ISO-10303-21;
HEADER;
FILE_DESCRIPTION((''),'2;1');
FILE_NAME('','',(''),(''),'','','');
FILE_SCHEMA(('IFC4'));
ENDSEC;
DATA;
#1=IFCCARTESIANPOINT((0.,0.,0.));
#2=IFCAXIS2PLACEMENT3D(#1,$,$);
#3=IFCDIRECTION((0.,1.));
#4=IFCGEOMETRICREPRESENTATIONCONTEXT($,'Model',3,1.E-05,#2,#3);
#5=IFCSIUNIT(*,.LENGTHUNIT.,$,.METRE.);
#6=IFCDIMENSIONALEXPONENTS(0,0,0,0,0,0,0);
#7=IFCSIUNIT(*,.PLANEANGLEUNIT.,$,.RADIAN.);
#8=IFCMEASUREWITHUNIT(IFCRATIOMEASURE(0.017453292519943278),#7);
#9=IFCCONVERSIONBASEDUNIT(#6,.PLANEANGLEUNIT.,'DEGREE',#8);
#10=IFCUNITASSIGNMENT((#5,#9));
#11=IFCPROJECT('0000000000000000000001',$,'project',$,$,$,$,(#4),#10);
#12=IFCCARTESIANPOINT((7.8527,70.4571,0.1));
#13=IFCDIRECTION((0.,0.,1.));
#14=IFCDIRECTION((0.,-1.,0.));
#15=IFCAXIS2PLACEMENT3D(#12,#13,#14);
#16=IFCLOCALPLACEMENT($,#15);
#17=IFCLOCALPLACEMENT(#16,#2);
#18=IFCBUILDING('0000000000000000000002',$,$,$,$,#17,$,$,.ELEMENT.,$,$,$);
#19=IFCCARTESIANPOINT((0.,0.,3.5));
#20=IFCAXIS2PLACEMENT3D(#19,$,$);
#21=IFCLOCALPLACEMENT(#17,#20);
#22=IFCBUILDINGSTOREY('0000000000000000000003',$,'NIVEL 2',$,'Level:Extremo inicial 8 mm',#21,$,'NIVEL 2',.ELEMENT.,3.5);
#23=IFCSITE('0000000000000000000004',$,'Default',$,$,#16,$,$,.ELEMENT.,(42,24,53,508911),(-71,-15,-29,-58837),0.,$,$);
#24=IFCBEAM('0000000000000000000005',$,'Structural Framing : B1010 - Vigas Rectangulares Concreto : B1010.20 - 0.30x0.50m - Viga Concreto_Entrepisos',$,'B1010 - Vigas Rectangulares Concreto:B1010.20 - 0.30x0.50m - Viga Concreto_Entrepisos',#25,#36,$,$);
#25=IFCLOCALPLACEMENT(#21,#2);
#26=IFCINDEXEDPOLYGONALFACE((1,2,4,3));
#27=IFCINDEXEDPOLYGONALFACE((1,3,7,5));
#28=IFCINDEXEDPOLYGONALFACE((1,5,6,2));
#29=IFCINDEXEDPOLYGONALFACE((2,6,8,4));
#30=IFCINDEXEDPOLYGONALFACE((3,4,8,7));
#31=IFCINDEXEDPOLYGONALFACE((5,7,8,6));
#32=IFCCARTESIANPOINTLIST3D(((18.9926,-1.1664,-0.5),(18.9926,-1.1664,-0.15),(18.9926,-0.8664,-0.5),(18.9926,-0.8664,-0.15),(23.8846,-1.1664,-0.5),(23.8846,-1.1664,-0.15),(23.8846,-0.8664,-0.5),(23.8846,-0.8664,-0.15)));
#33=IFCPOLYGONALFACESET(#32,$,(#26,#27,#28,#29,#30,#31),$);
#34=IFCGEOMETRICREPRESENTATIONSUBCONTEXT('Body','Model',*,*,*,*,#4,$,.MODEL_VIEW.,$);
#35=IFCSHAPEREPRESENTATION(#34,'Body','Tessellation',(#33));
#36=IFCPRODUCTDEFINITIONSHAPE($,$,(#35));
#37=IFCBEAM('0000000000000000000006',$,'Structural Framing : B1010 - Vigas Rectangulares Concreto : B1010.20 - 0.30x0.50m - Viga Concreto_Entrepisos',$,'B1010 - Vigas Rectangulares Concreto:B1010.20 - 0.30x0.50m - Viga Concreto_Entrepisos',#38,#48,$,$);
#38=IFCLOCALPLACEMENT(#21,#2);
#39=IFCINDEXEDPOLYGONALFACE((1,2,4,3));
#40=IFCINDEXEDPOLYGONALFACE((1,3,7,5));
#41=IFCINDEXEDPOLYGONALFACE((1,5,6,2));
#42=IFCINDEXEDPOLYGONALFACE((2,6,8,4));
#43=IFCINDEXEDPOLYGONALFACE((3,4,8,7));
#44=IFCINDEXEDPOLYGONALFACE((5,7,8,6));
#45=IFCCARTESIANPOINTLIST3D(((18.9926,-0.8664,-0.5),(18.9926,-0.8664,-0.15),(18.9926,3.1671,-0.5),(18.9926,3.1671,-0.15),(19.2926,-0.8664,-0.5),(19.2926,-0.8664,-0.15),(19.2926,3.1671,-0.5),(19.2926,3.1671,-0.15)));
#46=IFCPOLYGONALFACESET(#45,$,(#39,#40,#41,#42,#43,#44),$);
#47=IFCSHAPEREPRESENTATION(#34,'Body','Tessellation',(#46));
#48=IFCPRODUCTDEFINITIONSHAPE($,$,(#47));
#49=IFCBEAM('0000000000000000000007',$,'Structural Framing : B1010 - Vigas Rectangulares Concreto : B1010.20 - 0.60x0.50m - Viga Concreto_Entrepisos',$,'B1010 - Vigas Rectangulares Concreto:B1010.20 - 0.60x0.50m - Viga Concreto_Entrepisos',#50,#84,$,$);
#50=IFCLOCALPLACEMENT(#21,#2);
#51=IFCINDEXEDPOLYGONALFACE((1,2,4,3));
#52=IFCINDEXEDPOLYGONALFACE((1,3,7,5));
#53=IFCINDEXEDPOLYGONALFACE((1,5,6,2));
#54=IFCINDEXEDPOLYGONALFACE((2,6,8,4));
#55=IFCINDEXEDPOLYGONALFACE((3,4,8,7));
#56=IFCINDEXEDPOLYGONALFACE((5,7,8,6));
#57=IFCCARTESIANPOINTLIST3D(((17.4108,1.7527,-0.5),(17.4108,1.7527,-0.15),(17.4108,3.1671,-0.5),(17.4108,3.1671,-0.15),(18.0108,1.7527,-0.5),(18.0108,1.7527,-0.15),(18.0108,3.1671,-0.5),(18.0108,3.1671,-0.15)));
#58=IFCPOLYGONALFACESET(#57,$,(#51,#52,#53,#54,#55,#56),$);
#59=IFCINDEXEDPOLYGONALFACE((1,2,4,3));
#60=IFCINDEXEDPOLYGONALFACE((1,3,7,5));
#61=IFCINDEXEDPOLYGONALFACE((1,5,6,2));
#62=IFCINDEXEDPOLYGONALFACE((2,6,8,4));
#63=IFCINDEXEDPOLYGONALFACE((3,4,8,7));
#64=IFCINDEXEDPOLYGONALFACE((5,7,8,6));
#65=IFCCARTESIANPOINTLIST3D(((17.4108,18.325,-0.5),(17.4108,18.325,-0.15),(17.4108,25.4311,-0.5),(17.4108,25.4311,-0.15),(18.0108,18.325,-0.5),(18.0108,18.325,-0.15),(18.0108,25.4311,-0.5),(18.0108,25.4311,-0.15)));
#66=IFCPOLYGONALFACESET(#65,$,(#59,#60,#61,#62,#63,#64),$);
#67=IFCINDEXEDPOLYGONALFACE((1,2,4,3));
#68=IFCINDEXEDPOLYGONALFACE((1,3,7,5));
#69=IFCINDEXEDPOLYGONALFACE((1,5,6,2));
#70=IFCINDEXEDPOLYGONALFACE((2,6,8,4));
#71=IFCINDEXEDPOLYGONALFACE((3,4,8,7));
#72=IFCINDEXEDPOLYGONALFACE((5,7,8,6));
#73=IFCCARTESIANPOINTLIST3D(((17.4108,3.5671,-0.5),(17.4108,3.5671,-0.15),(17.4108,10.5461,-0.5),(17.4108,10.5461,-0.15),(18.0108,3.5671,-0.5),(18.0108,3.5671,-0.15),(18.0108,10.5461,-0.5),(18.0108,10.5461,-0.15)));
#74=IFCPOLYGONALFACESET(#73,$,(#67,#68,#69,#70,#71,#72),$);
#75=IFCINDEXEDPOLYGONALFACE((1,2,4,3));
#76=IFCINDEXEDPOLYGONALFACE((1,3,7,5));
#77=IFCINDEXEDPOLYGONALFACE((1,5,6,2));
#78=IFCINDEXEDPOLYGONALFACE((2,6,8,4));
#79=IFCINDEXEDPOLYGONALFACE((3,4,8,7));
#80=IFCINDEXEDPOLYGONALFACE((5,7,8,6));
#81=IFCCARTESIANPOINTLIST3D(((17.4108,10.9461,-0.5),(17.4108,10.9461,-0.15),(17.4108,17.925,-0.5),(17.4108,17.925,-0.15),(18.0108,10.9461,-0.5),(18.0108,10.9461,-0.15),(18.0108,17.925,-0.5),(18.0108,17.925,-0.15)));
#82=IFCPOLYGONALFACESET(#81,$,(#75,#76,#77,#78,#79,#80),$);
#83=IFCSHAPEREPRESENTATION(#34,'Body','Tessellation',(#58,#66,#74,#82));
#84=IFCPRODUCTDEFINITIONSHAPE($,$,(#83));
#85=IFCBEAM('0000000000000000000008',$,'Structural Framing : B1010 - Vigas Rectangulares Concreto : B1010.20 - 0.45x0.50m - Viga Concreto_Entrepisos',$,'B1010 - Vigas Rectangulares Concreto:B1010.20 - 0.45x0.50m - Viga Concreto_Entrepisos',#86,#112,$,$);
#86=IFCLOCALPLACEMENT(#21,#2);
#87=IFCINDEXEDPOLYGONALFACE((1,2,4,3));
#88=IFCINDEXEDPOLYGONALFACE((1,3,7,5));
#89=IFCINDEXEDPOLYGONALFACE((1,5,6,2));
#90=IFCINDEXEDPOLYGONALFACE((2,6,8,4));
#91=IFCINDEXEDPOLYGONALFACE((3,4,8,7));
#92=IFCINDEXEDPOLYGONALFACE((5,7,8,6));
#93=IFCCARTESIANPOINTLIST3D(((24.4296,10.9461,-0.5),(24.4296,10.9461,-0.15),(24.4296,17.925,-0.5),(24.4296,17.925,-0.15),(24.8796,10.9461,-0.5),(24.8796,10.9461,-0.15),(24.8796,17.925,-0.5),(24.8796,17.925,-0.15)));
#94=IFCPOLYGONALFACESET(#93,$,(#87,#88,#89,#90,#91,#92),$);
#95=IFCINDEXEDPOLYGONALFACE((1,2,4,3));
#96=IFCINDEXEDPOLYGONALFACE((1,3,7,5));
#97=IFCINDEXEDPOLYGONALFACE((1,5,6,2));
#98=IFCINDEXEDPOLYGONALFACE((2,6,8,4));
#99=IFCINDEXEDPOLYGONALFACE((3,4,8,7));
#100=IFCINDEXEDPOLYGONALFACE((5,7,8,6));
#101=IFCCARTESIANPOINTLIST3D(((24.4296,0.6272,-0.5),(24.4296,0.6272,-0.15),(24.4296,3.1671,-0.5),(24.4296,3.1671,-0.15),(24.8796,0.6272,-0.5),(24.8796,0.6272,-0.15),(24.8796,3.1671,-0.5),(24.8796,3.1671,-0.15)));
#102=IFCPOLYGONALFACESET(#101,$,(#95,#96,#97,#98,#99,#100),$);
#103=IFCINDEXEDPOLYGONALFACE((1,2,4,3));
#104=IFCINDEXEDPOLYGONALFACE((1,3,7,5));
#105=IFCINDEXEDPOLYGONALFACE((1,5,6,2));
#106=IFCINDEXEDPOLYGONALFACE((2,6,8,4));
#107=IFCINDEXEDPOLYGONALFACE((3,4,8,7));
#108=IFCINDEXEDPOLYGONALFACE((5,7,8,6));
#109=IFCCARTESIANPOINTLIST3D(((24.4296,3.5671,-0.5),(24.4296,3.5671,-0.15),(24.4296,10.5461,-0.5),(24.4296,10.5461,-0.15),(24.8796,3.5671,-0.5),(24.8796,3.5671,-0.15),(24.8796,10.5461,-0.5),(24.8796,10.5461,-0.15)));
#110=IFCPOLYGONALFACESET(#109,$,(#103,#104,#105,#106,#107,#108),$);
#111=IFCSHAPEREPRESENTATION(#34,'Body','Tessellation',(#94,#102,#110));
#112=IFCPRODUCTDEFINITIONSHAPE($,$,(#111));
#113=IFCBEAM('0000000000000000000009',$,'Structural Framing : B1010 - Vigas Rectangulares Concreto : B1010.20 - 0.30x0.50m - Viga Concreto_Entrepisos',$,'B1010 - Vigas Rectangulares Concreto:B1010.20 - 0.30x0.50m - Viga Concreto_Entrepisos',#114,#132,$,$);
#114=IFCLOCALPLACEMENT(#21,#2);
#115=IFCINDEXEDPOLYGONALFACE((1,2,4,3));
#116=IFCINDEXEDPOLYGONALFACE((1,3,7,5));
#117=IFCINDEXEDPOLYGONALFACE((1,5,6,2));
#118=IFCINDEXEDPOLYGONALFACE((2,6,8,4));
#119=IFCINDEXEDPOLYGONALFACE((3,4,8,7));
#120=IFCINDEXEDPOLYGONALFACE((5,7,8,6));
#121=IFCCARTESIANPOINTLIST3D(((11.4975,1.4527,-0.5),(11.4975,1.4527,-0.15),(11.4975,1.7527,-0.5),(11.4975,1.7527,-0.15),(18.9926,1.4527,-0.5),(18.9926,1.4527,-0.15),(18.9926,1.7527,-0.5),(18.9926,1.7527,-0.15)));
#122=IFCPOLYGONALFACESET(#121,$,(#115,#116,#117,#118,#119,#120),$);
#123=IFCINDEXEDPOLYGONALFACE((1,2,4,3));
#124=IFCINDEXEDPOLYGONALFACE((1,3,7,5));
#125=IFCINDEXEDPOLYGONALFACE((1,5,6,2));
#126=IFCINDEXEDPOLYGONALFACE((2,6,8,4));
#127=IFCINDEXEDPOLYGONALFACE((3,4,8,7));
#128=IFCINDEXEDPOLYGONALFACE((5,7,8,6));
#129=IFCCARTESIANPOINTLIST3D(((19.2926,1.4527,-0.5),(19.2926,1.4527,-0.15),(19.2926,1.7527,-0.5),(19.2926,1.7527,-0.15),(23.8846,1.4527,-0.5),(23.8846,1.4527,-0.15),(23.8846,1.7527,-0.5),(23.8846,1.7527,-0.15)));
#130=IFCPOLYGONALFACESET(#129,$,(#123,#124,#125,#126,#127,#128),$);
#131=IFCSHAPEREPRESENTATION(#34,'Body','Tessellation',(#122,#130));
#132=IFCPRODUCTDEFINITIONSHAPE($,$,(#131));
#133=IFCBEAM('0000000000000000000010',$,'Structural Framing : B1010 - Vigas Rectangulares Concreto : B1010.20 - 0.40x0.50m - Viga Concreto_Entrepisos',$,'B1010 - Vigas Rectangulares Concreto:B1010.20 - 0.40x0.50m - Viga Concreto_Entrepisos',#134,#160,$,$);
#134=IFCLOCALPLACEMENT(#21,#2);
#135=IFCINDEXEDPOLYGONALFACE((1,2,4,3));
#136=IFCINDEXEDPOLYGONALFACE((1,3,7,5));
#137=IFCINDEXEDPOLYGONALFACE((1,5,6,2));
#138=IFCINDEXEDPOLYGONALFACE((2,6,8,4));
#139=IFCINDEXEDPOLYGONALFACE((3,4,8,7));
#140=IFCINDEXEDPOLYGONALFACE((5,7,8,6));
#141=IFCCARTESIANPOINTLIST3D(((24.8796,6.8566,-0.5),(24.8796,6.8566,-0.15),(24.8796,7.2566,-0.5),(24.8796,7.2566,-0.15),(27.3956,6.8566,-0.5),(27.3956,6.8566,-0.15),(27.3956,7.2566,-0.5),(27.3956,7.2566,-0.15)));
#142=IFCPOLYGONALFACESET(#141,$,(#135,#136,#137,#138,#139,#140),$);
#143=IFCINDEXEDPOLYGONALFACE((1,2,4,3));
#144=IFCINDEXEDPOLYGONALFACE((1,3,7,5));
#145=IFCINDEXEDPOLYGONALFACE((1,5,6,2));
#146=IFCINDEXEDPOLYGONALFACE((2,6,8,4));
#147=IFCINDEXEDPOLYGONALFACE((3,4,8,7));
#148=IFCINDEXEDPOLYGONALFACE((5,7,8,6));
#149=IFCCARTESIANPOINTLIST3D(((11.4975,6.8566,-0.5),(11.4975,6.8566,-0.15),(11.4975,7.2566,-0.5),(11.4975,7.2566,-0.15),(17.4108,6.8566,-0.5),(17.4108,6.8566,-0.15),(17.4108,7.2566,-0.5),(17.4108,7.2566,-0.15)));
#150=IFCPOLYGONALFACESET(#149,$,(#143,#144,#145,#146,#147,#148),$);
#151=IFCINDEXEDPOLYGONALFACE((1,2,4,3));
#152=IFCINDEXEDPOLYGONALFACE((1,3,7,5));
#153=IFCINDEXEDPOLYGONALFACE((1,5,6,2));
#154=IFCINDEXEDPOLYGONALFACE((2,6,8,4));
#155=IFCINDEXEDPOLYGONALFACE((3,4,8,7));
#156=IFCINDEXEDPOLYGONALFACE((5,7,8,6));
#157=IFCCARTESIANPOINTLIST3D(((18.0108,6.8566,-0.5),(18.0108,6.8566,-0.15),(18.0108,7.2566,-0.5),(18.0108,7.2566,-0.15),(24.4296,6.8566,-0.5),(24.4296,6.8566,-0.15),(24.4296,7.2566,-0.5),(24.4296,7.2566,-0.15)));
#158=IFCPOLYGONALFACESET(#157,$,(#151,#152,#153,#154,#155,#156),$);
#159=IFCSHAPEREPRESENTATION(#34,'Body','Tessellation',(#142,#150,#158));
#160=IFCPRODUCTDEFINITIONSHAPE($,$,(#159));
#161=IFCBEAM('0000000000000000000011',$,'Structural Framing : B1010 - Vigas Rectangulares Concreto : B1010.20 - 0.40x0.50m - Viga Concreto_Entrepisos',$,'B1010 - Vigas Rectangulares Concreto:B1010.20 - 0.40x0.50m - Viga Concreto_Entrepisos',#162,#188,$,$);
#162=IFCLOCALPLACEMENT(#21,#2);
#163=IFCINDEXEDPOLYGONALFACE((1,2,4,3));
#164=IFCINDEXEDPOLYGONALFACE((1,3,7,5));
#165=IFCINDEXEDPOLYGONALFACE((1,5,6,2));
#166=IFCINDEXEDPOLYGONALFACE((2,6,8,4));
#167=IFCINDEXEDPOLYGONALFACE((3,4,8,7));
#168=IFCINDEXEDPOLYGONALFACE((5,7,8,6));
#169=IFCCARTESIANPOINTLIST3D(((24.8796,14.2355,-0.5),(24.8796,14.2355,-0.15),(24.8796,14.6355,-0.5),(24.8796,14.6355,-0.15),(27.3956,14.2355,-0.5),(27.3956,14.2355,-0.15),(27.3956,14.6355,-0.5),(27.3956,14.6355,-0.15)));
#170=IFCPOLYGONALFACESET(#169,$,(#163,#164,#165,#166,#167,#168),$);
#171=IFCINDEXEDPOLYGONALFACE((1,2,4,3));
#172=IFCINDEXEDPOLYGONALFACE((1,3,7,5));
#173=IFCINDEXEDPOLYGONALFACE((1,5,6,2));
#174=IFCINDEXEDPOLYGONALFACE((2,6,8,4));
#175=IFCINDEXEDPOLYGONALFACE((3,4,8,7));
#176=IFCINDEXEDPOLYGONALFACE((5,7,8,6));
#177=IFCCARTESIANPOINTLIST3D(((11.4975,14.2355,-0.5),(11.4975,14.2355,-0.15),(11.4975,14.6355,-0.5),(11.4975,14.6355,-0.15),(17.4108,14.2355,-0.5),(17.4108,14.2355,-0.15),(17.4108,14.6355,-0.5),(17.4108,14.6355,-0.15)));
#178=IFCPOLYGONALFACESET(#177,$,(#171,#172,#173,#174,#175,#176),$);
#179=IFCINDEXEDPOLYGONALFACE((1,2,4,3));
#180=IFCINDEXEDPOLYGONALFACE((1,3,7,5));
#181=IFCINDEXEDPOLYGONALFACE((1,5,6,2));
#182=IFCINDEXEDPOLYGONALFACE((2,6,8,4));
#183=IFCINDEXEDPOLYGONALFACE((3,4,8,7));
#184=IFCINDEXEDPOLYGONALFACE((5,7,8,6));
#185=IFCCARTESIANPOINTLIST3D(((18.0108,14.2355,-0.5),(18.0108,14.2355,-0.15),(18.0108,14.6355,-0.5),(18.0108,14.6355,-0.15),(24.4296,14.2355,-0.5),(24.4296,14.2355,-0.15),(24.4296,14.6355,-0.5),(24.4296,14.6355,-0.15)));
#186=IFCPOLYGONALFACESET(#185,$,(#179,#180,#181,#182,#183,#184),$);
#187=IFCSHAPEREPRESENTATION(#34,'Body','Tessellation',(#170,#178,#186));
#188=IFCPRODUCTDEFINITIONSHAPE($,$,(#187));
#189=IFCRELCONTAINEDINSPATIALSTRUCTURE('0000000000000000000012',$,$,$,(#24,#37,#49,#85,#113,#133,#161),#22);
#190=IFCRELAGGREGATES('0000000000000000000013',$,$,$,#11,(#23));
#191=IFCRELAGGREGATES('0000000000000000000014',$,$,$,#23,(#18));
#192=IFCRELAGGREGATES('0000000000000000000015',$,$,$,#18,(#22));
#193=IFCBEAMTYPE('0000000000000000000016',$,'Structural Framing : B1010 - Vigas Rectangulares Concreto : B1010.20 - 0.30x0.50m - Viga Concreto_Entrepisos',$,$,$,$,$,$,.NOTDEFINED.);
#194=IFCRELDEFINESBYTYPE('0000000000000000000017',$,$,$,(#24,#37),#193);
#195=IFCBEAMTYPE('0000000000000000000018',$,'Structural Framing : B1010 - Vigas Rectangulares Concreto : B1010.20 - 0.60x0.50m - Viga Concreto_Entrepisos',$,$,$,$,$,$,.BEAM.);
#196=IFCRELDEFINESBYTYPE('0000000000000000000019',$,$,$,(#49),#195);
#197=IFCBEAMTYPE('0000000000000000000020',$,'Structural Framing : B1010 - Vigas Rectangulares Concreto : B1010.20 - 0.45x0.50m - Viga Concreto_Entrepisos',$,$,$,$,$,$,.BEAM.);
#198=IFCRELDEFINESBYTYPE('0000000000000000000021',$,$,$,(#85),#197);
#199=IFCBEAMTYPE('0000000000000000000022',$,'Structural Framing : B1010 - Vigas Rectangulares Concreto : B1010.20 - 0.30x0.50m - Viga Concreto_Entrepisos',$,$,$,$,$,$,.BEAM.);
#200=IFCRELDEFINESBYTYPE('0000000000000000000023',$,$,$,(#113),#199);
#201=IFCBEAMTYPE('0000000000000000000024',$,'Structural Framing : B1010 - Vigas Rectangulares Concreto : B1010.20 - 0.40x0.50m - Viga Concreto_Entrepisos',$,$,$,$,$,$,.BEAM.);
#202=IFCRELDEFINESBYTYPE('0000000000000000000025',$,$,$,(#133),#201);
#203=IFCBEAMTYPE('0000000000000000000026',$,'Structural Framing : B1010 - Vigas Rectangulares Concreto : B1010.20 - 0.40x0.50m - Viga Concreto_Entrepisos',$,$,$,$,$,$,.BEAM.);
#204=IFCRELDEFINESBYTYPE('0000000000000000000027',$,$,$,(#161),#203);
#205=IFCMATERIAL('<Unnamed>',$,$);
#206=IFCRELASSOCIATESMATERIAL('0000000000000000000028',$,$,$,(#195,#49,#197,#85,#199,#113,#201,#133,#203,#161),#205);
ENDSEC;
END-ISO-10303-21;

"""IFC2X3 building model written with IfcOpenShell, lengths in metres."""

from ifc_helpers import new_model, entity, si_unit, converted_unit, direction, frame, frame_2d, origin, place, context, subcontext, project, spatial, rectangle, extrude, source, transform, mapped, material, type_object, type_shapes, element, save


model = new_model("IFC2X3")

# Units and contexts
model_context = context("Model", 3, precision=1e-05, world=origin(), true_north=direction((0.0, 1.0)))
body_context = subcontext(model_context, "Body", "Model", "MODEL_VIEW")
ifc_project = project(units=[si_unit("LENGTHUNIT", "METRE"), converted_unit("PLANEANGLEUNIT", "DEGREE", entity("IfcRatioMeasure", 0.017453292519943278), si_unit("PLANEANGLEUNIT", "RADIAN"), dimensions=[0, 0, 0, 0, 0, 0, 0])], contexts=[model_context])

# Site, building, storey
site_placement = place(None, frame((7.8527, 70.4571, 0.1), z_axis=(0.0, 0.0, 1.0), x_axis=(0.0, -1.0, 0.0)))
site = spatial("IfcSite", under=ifc_project, at=site_placement, Name="Default", CompositionType="ELEMENT", RefLatitude=(42, 24, 53, 508911), RefLongitude=(-71, -15, -29, -58837), RefElevation=0.0)
building_placement = place(site_placement, origin())
building = spatial("IfcBuilding", under=site, at=building_placement, CompositionType="ELEMENT")
storey_placement = place(building_placement, frame((0.0, 0.0, 3.5)))
storey = spatial("IfcBuildingStorey", under=building, at=storey_placement, Name="NIVEL 2", ObjectType="Level:Extremo inicial 8 mm", LongName="NIVEL 2", CompositionType="ELEMENT", Elevation=3.5)

# Shared definitions
ifc_material_1 = material(Name="<Unnamed>")

# Beams
beam_type_1 = type_object("IfcBeamType", Name="Structural Framing : B1010 - Vigas Rectangulares Concreto : B1010.20 - 0.30x0.50m - Viga Concreto_Entrepisos", PredefinedType="NOTDEFINED")
beam_1_placement = place(storey_placement, frame((19.1426, -1.0164, 0.0)))
element("IfcBeam", 1, at=beam_1_placement, inside=storey, type_object=beam_type_1, Name="Structural Framing : B1010 - Vigas Rectangulares Concreto : B1010.20 - 0.30x0.50m - Viga Concreto_Entrepisos", ObjectType="B1010 - Vigas Rectangulares Concreto:B1010.20 - 0.30x0.50m - Viga Concreto_Entrepisos", context=body_context, shape_type="SweptSolid", body=[
    extrude(rectangle(XDim=0.35, YDim=0.3, at=frame_2d((0.0, 0.0), x_axis=(1.0, 0.0))), frame((-0.15, 0.0, -0.325), z_axis=(1.0, 0.0, 0.0), x_axis=(0.0, 0.0, -1.0)), (0.0, 0.0, 1.0), 4.8921),
])
beam_2_placement = place(storey_placement, frame((19.1426, -1.0164, 0.0), z_axis=(0.0, 0.0, 1.0), x_axis=(0.0, 1.0, 0.0)))
element("IfcBeam", 2, at=beam_2_placement, inside=storey, type_object=beam_type_1, Name="Structural Framing : B1010 - Vigas Rectangulares Concreto : B1010.20 - 0.30x0.50m - Viga Concreto_Entrepisos", ObjectType="B1010 - Vigas Rectangulares Concreto:B1010.20 - 0.30x0.50m - Viga Concreto_Entrepisos", context=body_context, shape_type="SweptSolid", body=[
    extrude(rectangle(XDim=0.35, YDim=0.3, at=frame_2d((0.0, 0.0), x_axis=(1.0, 0.0))), frame((0.15, 0.0, -0.325), z_axis=(1.0, 0.0, 0.0), x_axis=(0.0, 0.0, -1.0)), (0.0, 0.0, 1.0), 4.0335),
])
beam_type_2 = type_object("IfcBeamType", Name="Structural Framing : B1010 - Vigas Rectangulares Concreto : B1010.20 - 0.60x0.50m - Viga Concreto_Entrepisos", PredefinedType="BEAM", material=ifc_material_1)
shared_shape_1 = source(origin(), body_context, "Body", "SweptSolid", [
    extrude(rectangle(XDim=0.35, YDim=0.6, at=frame_2d((0.0, 0.0), x_axis=(0.0, 1.0))), frame((17.7108, 3.1671, 3.175), z_axis=(0.0, -1.0, 0.0), x_axis=(-1.0, 0.0, 0.0)), (0.0, 0.0, 1.0), 1.4144),
    extrude(rectangle(XDim=0.35, YDim=0.6, at=frame_2d((0.0, 0.0), x_axis=(0.0, 1.0))), frame((17.7108, 25.4311, 3.175), z_axis=(0.0, -1.0, 0.0), x_axis=(-1.0, 0.0, 0.0)), (0.0, 0.0, 1.0), 7.106),
    extrude(rectangle(XDim=0.35, YDim=0.6, at=frame_2d((0.0, 0.0), x_axis=(0.0, 1.0))), frame((17.7108, 10.5461, 3.175), z_axis=(0.0, -1.0, 0.0), x_axis=(-1.0, 0.0, 0.0)), (0.0, 0.0, 1.0), 6.979),
    extrude(rectangle(XDim=0.35, YDim=0.6, at=frame_2d((0.0, 0.0), x_axis=(0.0, 1.0))), frame((17.7108, 17.925, 3.175), z_axis=(0.0, -1.0, 0.0), x_axis=(-1.0, 0.0, 0.0)), (0.0, 0.0, 1.0), 6.979),
])
type_shapes(beam_type_2, [shared_shape_1])
beam_3_placement = place(storey_placement, frame((0.0, 0.0, -3.5)))
element("IfcBeam", 3, at=beam_3_placement, inside=storey, type_object=beam_type_2, material=ifc_material_1, Name="Structural Framing : B1010 - Vigas Rectangulares Concreto : B1010.20 - 0.60x0.50m - Viga Concreto_Entrepisos", ObjectType="B1010 - Vigas Rectangulares Concreto:B1010.20 - 0.60x0.50m - Viga Concreto_Entrepisos", context=body_context, shape_type="MappedRepresentation", body=[
    mapped(shared_shape_1, transform((0.0, 0.0, 0.0), scale=1.0)),
])
beam_type_3 = type_object("IfcBeamType", Name="Structural Framing : B1010 - Vigas Rectangulares Concreto : B1010.20 - 0.45x0.50m - Viga Concreto_Entrepisos", PredefinedType="BEAM", material=ifc_material_1)
shared_shape_2 = source(origin(), body_context, "Body", "SweptSolid", [
    extrude(rectangle(XDim=0.35, YDim=0.45, at=frame_2d((0.0, 0.0), x_axis=(0.0, 1.0))), frame((24.6546, 10.9461, 3.175), z_axis=(0.0, 1.0, 0.0), x_axis=(-1.0, 0.0, 0.0)), (0.0, 0.0, 1.0), 6.979),
    extrude(rectangle(XDim=0.35, YDim=0.45, at=frame_2d((0.0, 0.0), x_axis=(0.0, 1.0))), frame((24.6546, 0.6272, 3.175), z_axis=(0.0, 1.0, 0.0), x_axis=(-1.0, 0.0, 0.0)), (0.0, 0.0, 1.0), 2.5399),
    extrude(rectangle(XDim=0.35, YDim=0.45, at=frame_2d((0.0, 0.0), x_axis=(0.0, 1.0))), frame((24.6546, 3.5671, 3.175), z_axis=(0.0, 1.0, 0.0), x_axis=(-1.0, 0.0, 0.0)), (0.0, 0.0, 1.0), 6.979),
])
type_shapes(beam_type_3, [shared_shape_2])
beam_4_placement = place(storey_placement, frame((0.0, 0.0, -3.5)))
element("IfcBeam", 4, at=beam_4_placement, inside=storey, type_object=beam_type_3, material=ifc_material_1, Name="Structural Framing : B1010 - Vigas Rectangulares Concreto : B1010.20 - 0.45x0.50m - Viga Concreto_Entrepisos", ObjectType="B1010 - Vigas Rectangulares Concreto:B1010.20 - 0.45x0.50m - Viga Concreto_Entrepisos", context=body_context, shape_type="MappedRepresentation", body=[
    mapped(shared_shape_2, transform((0.0, 0.0, 0.0), scale=1.0)),
])
beam_type_4 = type_object("IfcBeamType", Name="Structural Framing : B1010 - Vigas Rectangulares Concreto : B1010.20 - 0.30x0.50m - Viga Concreto_Entrepisos", PredefinedType="BEAM", material=ifc_material_1)
shared_shape_3 = source(origin(), body_context, "Body", "SweptSolid", [
    extrude(rectangle(XDim=0.35, YDim=0.3, at=frame_2d((0.0, 0.0), x_axis=(1.0, 0.0))), frame((11.4975, 1.6027, 3.175), z_axis=(1.0, 0.0, 0.0), x_axis=(0.0, 0.0, -1.0)), (0.0, 0.0, 1.0), 7.495),
    extrude(rectangle(XDim=0.35, YDim=0.3, at=frame_2d((0.0, 0.0), x_axis=(1.0, 0.0))), frame((19.2926, 1.6027, 3.175), z_axis=(1.0, 0.0, 0.0), x_axis=(0.0, 0.0, -1.0)), (0.0, 0.0, 1.0), 4.5921),
])
type_shapes(beam_type_4, [shared_shape_3])
beam_5_placement = place(storey_placement, frame((0.0, 0.0, -3.5)))
element("IfcBeam", 5, at=beam_5_placement, inside=storey, type_object=beam_type_4, material=ifc_material_1, Name="Structural Framing : B1010 - Vigas Rectangulares Concreto : B1010.20 - 0.30x0.50m - Viga Concreto_Entrepisos", ObjectType="B1010 - Vigas Rectangulares Concreto:B1010.20 - 0.30x0.50m - Viga Concreto_Entrepisos", context=body_context, shape_type="MappedRepresentation", body=[
    mapped(shared_shape_3, transform((0.0, 0.0, 0.0), scale=1.0)),
])
beam_type_5 = type_object("IfcBeamType", Name="Structural Framing : B1010 - Vigas Rectangulares Concreto : B1010.20 - 0.40x0.50m - Viga Concreto_Entrepisos", PredefinedType="BEAM", material=ifc_material_1)
shared_shape_4 = source(origin(), body_context, "Body", "SweptSolid", [
    extrude(rectangle(XDim=0.35, YDim=0.4, at=frame_2d((0.0, 0.0), x_axis=(1.0, 0.0))), frame((24.8796, 7.0566, 3.175), z_axis=(1.0, 0.0, 0.0), x_axis=(0.0, 0.0, -1.0)), (0.0, 0.0, 1.0), 2.5159),
    extrude(rectangle(XDim=0.35, YDim=0.4, at=frame_2d((0.0, 0.0), x_axis=(1.0, 0.0))), frame((11.4975, 7.0566, 3.175), z_axis=(1.0, 0.0, 0.0), x_axis=(0.0, 0.0, -1.0)), (0.0, 0.0, 1.0), 5.9133),
    extrude(rectangle(XDim=0.35, YDim=0.4, at=frame_2d((0.0, 0.0), x_axis=(1.0, 0.0))), frame((18.0108, 7.0566, 3.175), z_axis=(1.0, 0.0, 0.0), x_axis=(0.0, 0.0, -1.0)), (0.0, 0.0, 1.0), 6.4188),
])
type_shapes(beam_type_5, [shared_shape_4])
beam_6_placement = place(storey_placement, frame((0.0, 0.0, -3.5)))
element("IfcBeam", 6, at=beam_6_placement, inside=storey, type_object=beam_type_5, material=ifc_material_1, Name="Structural Framing : B1010 - Vigas Rectangulares Concreto : B1010.20 - 0.40x0.50m - Viga Concreto_Entrepisos", ObjectType="B1010 - Vigas Rectangulares Concreto:B1010.20 - 0.40x0.50m - Viga Concreto_Entrepisos", context=body_context, shape_type="MappedRepresentation", body=[
    mapped(shared_shape_4, transform((0.0, 0.0, 0.0), scale=1.0)),
])
beam_type_6 = type_object("IfcBeamType", Name="Structural Framing : B1010 - Vigas Rectangulares Concreto : B1010.20 - 0.40x0.50m - Viga Concreto_Entrepisos", PredefinedType="BEAM", material=ifc_material_1)
shared_shape_5 = source(origin(), body_context, "Body", "SweptSolid", [
    extrude(rectangle(XDim=0.35, YDim=0.4, at=frame_2d((0.0, 0.0), x_axis=(1.0, 0.0))), frame((24.8796, 14.4355, 3.175), z_axis=(1.0, 0.0, 0.0), x_axis=(0.0, 0.0, -1.0)), (0.0, 0.0, 1.0), 2.5159),
    extrude(rectangle(XDim=0.35, YDim=0.4, at=frame_2d((0.0, 0.0), x_axis=(1.0, 0.0))), frame((11.4975, 14.4355, 3.175), z_axis=(1.0, 0.0, 0.0), x_axis=(0.0, 0.0, -1.0)), (0.0, 0.0, 1.0), 5.9133),
    extrude(rectangle(XDim=0.35, YDim=0.4, at=frame_2d((0.0, 0.0), x_axis=(1.0, 0.0))), frame((18.0108, 14.4355, 3.175), z_axis=(1.0, 0.0, 0.0), x_axis=(0.0, 0.0, -1.0)), (0.0, 0.0, 1.0), 6.4188),
])
type_shapes(beam_type_6, [shared_shape_5])
beam_7_placement = place(storey_placement, frame((0.0, 0.0, -3.5)))
element("IfcBeam", 7, at=beam_7_placement, inside=storey, type_object=beam_type_6, material=ifc_material_1, Name="Structural Framing : B1010 - Vigas Rectangulares Concreto : B1010.20 - 0.40x0.50m - Viga Concreto_Entrepisos", ObjectType="B1010 - Vigas Rectangulares Concreto:B1010.20 - 0.40x0.50m - Viga Concreto_Entrepisos", context=body_context, shape_type="MappedRepresentation", body=[
    mapped(shared_shape_5, transform((0.0, 0.0, 0.0), scale=1.0)),
])

save(model, "model.ifc")
